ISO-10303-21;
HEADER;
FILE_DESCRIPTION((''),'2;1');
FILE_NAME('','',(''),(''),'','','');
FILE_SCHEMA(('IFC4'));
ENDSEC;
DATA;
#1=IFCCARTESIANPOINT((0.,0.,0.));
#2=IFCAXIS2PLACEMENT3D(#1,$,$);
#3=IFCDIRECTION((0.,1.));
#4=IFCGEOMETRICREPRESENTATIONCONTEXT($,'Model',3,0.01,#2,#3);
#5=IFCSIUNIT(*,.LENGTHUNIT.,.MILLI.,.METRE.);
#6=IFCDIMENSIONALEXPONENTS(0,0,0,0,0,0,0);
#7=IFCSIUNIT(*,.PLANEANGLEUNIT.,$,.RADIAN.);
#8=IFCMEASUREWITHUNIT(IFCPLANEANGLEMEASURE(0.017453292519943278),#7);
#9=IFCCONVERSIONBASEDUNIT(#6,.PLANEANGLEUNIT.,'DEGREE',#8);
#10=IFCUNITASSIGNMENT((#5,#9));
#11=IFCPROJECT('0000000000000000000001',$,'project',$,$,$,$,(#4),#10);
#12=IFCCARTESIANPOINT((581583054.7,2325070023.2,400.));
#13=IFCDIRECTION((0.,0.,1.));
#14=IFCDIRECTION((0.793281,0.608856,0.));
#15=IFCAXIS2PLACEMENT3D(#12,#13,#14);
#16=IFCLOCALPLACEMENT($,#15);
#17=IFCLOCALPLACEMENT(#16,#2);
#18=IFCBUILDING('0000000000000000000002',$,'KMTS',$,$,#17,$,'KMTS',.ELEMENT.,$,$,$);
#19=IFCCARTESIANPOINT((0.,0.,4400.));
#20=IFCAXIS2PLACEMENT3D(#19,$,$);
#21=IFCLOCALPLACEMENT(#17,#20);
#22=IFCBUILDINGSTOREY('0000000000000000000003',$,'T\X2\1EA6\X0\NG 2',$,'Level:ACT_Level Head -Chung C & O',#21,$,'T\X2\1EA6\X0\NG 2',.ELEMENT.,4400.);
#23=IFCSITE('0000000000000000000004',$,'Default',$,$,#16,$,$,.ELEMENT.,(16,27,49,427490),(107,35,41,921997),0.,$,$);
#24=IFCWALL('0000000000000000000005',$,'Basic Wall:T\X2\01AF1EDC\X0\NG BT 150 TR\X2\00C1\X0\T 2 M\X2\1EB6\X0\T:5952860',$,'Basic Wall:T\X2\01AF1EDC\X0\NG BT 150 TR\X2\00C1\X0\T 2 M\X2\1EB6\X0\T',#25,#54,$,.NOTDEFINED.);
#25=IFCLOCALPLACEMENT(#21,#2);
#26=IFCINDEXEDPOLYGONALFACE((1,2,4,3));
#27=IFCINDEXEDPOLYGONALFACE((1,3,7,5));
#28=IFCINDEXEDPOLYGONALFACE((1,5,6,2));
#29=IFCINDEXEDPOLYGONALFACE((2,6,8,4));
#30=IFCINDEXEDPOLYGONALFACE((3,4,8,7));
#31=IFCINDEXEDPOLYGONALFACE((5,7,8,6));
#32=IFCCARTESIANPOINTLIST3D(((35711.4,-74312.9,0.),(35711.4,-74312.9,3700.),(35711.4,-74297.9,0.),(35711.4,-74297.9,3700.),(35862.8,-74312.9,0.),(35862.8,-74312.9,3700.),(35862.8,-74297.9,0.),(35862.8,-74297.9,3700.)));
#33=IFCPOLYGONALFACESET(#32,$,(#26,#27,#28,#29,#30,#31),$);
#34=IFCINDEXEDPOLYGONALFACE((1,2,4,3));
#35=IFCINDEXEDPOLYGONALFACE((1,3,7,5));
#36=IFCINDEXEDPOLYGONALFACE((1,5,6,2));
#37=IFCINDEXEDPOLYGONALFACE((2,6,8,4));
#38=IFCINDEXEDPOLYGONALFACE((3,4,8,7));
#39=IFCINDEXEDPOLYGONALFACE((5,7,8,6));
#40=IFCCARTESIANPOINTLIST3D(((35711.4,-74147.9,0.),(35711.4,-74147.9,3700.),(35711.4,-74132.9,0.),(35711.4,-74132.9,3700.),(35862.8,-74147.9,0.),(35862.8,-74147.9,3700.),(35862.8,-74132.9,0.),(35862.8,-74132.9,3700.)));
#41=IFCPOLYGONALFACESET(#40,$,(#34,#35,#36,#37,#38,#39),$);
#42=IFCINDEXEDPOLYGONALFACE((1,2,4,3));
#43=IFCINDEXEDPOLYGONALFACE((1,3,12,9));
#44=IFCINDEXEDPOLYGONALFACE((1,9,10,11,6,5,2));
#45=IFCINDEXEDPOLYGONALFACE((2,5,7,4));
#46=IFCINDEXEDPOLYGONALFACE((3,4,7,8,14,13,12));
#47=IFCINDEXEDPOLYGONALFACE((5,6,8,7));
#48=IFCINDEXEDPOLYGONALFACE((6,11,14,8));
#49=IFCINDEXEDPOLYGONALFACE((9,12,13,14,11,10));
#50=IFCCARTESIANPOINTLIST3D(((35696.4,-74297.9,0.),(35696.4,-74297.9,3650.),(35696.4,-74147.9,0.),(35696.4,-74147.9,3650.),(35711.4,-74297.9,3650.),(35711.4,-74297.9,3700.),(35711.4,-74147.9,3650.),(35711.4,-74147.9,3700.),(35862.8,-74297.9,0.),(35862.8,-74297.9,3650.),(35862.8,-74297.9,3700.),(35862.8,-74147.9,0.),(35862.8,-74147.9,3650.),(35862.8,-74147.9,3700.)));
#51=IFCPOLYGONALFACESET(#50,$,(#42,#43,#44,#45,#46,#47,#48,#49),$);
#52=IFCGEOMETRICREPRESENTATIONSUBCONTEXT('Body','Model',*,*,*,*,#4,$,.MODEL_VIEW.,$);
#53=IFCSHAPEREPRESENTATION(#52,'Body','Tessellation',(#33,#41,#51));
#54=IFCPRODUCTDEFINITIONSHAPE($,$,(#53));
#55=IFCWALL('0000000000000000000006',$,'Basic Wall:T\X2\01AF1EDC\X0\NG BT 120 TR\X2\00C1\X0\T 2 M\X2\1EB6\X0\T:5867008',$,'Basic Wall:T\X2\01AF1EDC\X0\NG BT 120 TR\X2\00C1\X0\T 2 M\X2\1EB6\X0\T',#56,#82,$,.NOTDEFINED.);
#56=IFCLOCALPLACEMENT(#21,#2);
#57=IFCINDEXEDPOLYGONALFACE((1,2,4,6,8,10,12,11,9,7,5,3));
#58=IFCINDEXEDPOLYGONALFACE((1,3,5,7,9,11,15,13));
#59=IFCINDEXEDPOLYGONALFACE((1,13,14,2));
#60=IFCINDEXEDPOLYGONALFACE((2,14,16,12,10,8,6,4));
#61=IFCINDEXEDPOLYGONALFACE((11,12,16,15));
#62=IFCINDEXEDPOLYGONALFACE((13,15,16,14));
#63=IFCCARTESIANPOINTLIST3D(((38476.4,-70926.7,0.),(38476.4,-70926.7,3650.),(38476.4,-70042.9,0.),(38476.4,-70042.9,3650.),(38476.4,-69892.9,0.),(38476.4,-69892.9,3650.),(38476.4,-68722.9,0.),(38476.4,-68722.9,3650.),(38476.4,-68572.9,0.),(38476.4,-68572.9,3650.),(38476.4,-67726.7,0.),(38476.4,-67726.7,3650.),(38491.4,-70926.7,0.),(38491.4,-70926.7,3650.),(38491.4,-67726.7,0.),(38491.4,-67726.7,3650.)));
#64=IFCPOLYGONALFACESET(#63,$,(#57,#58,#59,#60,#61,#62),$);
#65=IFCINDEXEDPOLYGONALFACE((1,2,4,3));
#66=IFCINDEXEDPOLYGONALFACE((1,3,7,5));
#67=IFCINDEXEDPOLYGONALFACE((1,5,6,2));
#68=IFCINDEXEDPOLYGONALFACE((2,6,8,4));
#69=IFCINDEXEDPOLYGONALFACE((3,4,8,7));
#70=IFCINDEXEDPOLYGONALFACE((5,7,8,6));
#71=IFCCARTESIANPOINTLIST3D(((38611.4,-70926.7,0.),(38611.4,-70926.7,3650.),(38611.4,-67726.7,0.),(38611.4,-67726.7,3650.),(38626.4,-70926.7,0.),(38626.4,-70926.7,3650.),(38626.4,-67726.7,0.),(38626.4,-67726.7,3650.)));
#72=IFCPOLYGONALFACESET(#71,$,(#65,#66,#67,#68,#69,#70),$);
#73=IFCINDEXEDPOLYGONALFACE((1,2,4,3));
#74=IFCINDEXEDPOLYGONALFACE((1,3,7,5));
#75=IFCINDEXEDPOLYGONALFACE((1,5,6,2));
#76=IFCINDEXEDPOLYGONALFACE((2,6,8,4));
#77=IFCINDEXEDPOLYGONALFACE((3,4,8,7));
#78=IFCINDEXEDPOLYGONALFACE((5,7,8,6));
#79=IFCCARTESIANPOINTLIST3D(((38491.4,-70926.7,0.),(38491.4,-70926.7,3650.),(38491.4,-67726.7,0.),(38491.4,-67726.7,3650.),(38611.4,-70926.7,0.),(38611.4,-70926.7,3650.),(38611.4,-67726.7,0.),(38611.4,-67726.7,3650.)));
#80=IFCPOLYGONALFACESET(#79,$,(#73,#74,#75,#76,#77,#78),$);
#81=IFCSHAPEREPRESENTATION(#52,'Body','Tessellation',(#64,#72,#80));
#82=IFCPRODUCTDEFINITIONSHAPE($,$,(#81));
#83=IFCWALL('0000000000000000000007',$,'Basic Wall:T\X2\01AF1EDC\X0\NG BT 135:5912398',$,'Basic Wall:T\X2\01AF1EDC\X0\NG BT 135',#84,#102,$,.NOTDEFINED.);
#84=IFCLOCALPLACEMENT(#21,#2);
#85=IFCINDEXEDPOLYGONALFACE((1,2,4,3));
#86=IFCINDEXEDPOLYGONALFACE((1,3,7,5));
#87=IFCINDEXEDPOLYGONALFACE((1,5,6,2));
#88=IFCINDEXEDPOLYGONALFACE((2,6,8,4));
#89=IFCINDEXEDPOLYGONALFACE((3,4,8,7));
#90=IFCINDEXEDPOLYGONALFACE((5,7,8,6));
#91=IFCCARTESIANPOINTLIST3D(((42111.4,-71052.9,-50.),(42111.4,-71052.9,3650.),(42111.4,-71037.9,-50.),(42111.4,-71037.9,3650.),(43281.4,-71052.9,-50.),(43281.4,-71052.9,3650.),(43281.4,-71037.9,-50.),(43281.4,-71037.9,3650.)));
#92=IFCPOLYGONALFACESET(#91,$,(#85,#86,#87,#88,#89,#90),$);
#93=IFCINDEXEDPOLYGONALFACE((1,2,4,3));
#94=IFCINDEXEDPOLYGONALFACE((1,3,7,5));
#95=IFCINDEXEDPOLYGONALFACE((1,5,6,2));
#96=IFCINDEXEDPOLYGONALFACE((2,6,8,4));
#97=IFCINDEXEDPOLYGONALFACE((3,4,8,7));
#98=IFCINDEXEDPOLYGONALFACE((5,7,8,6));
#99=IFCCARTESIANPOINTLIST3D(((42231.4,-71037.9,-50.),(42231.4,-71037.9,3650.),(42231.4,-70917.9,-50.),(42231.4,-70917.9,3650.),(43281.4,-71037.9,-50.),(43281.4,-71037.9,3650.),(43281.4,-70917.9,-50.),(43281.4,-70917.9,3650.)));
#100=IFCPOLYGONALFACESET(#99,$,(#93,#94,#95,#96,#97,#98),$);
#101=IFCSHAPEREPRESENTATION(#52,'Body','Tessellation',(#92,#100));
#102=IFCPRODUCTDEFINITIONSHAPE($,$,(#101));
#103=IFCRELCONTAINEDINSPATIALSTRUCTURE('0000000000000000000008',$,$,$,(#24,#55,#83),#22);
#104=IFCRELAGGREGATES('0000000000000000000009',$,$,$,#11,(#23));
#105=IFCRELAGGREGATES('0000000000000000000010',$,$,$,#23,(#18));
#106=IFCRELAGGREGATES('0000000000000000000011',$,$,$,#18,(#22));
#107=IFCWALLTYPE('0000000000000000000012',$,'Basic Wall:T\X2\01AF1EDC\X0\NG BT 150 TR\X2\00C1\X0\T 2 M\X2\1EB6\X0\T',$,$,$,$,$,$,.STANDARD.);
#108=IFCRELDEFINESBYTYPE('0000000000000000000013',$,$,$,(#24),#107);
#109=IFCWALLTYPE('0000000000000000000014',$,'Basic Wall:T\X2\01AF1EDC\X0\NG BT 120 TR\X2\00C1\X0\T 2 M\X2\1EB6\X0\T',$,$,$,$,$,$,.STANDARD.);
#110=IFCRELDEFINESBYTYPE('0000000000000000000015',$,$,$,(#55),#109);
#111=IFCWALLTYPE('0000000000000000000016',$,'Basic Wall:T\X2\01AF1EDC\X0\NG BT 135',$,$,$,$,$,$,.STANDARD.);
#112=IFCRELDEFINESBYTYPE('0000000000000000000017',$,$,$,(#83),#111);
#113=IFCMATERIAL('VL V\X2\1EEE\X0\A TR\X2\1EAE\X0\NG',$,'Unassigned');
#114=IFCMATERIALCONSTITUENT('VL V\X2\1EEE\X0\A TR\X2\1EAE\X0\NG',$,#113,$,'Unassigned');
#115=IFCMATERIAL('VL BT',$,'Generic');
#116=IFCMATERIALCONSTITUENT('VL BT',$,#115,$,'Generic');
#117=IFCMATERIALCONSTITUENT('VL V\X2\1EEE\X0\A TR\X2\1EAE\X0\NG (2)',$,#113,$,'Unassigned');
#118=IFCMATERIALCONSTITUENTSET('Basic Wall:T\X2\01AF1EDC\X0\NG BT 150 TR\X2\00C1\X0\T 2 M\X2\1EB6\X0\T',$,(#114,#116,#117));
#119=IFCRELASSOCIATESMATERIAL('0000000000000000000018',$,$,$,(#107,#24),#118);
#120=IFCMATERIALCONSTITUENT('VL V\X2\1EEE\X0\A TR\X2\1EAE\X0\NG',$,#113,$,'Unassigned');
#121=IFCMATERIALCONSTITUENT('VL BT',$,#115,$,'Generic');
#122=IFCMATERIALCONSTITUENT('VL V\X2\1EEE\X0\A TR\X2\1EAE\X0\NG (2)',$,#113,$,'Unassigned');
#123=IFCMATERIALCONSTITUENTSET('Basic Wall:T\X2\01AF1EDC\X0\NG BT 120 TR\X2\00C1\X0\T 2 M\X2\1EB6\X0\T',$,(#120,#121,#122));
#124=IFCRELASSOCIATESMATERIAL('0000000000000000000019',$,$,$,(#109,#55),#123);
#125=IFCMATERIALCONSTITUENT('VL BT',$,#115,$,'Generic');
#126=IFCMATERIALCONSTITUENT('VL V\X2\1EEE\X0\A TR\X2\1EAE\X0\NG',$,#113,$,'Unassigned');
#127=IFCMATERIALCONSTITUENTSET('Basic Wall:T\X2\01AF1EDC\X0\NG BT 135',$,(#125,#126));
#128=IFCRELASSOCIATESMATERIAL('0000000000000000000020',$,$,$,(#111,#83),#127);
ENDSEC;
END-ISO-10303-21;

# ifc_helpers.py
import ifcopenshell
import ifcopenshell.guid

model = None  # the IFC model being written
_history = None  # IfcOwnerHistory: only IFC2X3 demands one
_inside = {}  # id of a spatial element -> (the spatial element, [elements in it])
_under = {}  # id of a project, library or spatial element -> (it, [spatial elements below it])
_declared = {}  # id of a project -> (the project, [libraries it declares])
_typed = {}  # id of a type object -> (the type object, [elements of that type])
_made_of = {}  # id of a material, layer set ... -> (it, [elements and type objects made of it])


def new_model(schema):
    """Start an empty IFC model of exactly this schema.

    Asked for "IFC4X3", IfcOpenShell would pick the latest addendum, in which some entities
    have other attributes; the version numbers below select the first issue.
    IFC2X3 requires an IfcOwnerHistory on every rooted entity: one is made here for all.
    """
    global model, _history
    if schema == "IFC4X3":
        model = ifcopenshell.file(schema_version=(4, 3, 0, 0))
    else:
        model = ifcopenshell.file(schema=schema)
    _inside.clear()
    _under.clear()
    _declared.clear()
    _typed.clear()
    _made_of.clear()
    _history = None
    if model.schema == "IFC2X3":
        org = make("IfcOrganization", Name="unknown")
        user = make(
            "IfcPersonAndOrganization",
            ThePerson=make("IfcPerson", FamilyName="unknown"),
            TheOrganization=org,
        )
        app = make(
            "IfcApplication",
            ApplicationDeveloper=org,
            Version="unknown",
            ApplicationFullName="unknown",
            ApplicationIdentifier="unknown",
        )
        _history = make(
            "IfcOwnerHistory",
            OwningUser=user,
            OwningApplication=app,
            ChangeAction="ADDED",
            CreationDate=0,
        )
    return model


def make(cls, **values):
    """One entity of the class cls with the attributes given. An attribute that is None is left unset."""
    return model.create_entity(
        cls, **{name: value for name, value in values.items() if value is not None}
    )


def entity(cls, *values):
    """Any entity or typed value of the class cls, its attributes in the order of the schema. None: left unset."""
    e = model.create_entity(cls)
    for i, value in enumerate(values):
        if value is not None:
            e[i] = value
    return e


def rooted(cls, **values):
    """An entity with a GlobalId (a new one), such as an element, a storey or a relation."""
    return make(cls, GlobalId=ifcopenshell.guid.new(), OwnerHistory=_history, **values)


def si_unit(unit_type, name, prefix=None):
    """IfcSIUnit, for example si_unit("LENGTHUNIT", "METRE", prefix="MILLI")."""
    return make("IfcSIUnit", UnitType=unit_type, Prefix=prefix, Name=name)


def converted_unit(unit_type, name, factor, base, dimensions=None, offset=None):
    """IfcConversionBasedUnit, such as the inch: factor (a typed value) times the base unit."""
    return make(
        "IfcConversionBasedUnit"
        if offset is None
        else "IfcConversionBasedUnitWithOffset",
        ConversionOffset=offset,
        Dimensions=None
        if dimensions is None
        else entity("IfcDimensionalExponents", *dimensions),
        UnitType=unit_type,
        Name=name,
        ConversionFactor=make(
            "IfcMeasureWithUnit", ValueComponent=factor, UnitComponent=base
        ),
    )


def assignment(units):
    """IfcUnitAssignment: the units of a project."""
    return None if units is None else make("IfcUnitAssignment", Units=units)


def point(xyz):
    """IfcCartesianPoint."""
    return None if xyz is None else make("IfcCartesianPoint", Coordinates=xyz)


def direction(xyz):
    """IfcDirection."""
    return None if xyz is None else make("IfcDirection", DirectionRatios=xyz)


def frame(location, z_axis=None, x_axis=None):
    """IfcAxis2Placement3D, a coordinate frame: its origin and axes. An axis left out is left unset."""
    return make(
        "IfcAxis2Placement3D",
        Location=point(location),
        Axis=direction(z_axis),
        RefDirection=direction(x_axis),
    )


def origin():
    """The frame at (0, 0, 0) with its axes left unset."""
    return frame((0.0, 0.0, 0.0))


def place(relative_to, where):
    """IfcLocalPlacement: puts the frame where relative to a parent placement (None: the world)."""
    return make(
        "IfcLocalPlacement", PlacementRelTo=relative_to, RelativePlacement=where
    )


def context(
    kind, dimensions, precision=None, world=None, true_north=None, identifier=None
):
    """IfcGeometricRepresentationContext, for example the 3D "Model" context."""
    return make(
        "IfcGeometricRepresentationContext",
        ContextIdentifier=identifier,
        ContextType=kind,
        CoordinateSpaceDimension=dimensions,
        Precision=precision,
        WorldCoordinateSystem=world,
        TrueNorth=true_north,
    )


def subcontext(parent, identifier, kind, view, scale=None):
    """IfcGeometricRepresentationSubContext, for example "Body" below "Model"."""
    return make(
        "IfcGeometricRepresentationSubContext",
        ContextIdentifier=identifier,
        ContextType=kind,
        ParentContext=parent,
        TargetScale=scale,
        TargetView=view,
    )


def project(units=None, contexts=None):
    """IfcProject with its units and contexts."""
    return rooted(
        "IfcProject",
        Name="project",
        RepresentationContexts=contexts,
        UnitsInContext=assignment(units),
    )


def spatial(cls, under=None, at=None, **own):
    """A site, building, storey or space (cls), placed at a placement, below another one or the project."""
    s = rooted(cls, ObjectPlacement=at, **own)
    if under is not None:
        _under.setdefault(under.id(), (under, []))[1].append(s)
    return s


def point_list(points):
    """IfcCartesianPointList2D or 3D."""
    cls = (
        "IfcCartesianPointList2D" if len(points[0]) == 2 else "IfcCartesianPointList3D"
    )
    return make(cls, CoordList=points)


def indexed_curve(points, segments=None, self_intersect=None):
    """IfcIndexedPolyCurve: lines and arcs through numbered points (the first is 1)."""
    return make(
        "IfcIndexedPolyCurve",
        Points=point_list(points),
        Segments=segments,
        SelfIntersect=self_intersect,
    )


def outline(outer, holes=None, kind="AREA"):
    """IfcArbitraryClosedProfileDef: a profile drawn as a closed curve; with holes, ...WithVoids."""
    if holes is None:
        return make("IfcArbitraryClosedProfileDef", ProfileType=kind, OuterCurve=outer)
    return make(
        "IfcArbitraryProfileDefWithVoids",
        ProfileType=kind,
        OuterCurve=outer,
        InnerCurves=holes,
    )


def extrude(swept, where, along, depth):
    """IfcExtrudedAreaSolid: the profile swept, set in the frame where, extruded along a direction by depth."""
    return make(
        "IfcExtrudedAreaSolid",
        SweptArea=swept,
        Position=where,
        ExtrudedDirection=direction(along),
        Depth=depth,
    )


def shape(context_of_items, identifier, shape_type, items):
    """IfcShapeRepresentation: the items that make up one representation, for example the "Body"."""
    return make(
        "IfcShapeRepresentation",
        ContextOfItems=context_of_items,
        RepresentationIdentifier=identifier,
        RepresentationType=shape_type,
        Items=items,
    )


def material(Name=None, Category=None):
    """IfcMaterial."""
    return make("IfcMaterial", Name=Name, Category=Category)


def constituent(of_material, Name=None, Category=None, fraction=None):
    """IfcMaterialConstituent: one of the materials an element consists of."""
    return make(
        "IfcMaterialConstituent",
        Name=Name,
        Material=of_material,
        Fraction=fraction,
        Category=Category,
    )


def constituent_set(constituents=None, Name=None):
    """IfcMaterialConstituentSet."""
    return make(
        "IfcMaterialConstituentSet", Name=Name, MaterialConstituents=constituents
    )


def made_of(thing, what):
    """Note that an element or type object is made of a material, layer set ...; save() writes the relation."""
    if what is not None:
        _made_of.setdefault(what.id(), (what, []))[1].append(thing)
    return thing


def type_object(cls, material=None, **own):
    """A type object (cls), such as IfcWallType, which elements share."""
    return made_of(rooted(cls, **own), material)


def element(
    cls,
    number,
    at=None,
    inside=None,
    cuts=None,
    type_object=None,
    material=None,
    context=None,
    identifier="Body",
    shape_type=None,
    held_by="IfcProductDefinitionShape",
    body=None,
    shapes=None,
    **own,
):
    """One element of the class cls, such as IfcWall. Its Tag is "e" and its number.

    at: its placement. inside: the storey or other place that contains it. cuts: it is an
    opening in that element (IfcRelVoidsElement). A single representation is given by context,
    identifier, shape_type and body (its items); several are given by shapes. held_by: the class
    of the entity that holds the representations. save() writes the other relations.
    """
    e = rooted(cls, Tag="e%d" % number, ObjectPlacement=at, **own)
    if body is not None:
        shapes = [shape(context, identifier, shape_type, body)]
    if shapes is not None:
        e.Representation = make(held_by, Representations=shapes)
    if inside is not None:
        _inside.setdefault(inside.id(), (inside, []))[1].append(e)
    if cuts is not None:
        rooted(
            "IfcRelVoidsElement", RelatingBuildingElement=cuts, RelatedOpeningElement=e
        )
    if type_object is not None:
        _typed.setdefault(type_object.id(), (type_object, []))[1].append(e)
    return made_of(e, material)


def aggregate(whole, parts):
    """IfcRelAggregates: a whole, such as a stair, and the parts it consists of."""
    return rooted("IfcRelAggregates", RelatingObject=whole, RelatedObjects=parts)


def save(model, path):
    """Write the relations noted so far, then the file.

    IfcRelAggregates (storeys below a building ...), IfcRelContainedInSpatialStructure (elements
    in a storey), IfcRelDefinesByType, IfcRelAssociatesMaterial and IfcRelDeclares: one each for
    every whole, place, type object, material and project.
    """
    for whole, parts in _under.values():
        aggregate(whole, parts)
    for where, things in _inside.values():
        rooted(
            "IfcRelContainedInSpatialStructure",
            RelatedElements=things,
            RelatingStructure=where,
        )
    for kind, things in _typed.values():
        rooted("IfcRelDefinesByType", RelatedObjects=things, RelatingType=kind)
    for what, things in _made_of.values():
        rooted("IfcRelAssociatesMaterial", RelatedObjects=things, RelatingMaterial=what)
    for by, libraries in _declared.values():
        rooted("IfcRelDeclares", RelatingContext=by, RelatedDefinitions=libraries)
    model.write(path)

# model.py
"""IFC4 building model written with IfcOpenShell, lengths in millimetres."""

from ifc_helpers import new_model, entity, si_unit, converted_unit, direction, frame, origin, place, context, subcontext, project, spatial, indexed_curve, outline, extrude, material, constituent, constituent_set, type_object, element, save


model = new_model("IFC4")

# Units and contexts
model_context = context("Model", 3, precision=0.01, world=origin(), true_north=direction((0.0, 1.0)))
body_context = subcontext(model_context, "Body", "Model", "MODEL_VIEW")
ifc_project = project(units=[si_unit("LENGTHUNIT", "METRE", prefix="MILLI"), converted_unit("PLANEANGLEUNIT", "DEGREE", entity("IfcPlaneAngleMeasure", 0.017453292519943278), si_unit("PLANEANGLEUNIT", "RADIAN"), dimensions=[0, 0, 0, 0, 0, 0, 0])], contexts=[model_context])

# Site, building, storey
site_placement = place(None, frame((581583054.7, 2325070023.2, 400.0), z_axis=(0.0, 0.0, 1.0), x_axis=(0.793281, 0.608856, 0.0)))
site = spatial("IfcSite", under=ifc_project, at=site_placement, Name="Default", CompositionType="ELEMENT", RefLatitude=(16, 27, 49, 427490), RefLongitude=(107, 35, 41, 921997), RefElevation=0.0)
building_placement = place(site_placement, origin())
building = spatial("IfcBuilding", under=site, at=building_placement, Name="KMTS", LongName="KMTS", CompositionType="ELEMENT")
storey_placement = place(building_placement, frame((0.0, 0.0, 4400.0)))
storey = spatial("IfcBuildingStorey", under=building, at=storey_placement, Name="TẦNG 2", ObjectType="Level:ACT_Level Head -Chung C & O", LongName="TẦNG 2", CompositionType="ELEMENT", Elevation=4400.0)

# Shared definitions
ifc_material_1 = material(Name="VL VỮA TRẮNG", Category="Unassigned")
ifc_constituent_1 = constituent(ifc_material_1, Name="VL VỮA TRẮNG", Category="Unassigned")
ifc_material_2 = material(Name="VL BT", Category="Generic")
ifc_constituent_2 = constituent(ifc_material_2, Name="VL BT", Category="Generic")
ifc_constituent_3 = constituent(ifc_material_1, Name="VL VỮA TRẮNG (2)", Category="Unassigned")
ifc_constituent_set_1 = constituent_set(constituents=[ifc_constituent_1, ifc_constituent_2, ifc_constituent_3], Name="Basic Wall:TƯỜNG BT 150 TRÁT 2 MẶT")
wall_type_1 = type_object("IfcWallType", Name="Basic Wall:TƯỜNG BT 150 TRÁT 2 MẶT", PredefinedType="STANDARD", material=ifc_constituent_set_1)

# Wall
wall_1_placement = place(storey_placement, frame((35711.4, -74222.9, 0.0)))
element("IfcWall", 1, at=wall_1_placement, inside=storey, type_object=wall_type_1, material=ifc_constituent_set_1, Name="Basic Wall:TƯỜNG BT 150 TRÁT 2 MẶT:5952860", ObjectType="Basic Wall:TƯỜNG BT 150 TRÁT 2 MẶT", PredefinedType="NOTDEFINED", context=body_context, shape_type="SweptSolid", body=[
    extrude(outline(indexed_curve([(-7.5, -75.7), (7.5, -75.7), (7.5, 75.7), (-7.5, 75.7), (-7.5, -75.7)], self_intersect=False)), frame((75.7, -82.5, 0.0), z_axis=(0.0, 0.0, 1.0), x_axis=(0.0, 1.0, 0.0)), (0.0, 0.0, 1.0), 3700.0),
    extrude(outline(indexed_curve([(-7.5, -75.7), (7.5, -75.7), (7.5, 75.7), (-7.5, 75.7), (-7.5, -75.7)], self_intersect=False)), frame((75.7, 82.5, 0.0), z_axis=(0.0, 0.0, 1.0), x_axis=(0.0, -1.0, 0.0)), (0.0, 0.0, 1.0), 3700.0),
    extrude(outline(indexed_curve([(-2621.4, -75.6), (1028.6, -75.6), (1028.6, -60.6), (1078.6, -60.6), (1078.6, 90.8), (1028.6, 90.8), (-2621.4, 90.8), (-2621.4, -75.6)], self_intersect=False)), frame((60.6, -75.0, 2621.4), z_axis=(0.0, 1.0, 0.0), x_axis=(0.0, 0.0, 1.0)), (0.0, 0.0, 1.0), 150.0),
])
ifc_constituent_4 = constituent(ifc_material_1, Name="VL VỮA TRẮNG", Category="Unassigned")
ifc_constituent_5 = constituent(ifc_material_2, Name="VL BT", Category="Generic")
ifc_constituent_6 = constituent(ifc_material_1, Name="VL VỮA TRẮNG (2)", Category="Unassigned")
ifc_constituent_set_2 = constituent_set(constituents=[ifc_constituent_4, ifc_constituent_5, ifc_constituent_6], Name="Basic Wall:TƯỜNG BT 120 TRÁT 2 MẶT")
wall_type_2 = type_object("IfcWallType", Name="Basic Wall:TƯỜNG BT 120 TRÁT 2 MẶT", PredefinedType="STANDARD", material=ifc_constituent_set_2)

# Wall
wall_2_placement = place(storey_placement, frame((38551.4, -67726.7, 0.0), z_axis=(0.0, 0.0, 1.0), x_axis=(0.0, -1.0, 0.0)))
element("IfcWall", 2, at=wall_2_placement, inside=storey, type_object=wall_type_2, material=ifc_constituent_set_2, Name="Basic Wall:TƯỜNG BT 120 TRÁT 2 MẶT:5867008", ObjectType="Basic Wall:TƯỜNG BT 120 TRÁT 2 MẶT", PredefinedType="NOTDEFINED", context=body_context, shape_type="SweptSolid", body=[
    extrude(outline(indexed_curve([(-744.4, -3.7), (-594.4, -3.7), (575.6, -3.7), (725.6, -3.7), (1609.4, -3.7), (1609.4, 11.3), (-1590.6, 11.3), (-1590.6, -3.7), (-744.4, -3.7)], self_intersect=False)), frame((1590.6, -71.3, 0.0)), (0.0, 0.0, 1.0), 3650.0),
    extrude(outline(indexed_curve([(-7.5, -1600.0), (7.5, -1600.0), (7.5, 1600.0), (-7.5, 1600.0), (-7.5, -1600.0)], self_intersect=False)), frame((1600.0, 67.5, 0.0), z_axis=(0.0, 0.0, 1.0), x_axis=(0.0, -1.0, 0.0)), (0.0, 0.0, 1.0), 3650.0),
    extrude(outline(indexed_curve([(-1600.0, -60.0), (1600.0, -60.0), (1600.0, 60.0), (-1600.0, 60.0), (-1600.0, -60.0)], self_intersect=False)), frame((1600.0, 0.0, 0.0)), (0.0, 0.0, 1.0), 3650.0),
])

# Wall
ifc_constituent_7 = constituent(ifc_material_2, Name="VL BT", Category="Generic")
ifc_constituent_8 = constituent(ifc_material_1, Name="VL VỮA TRẮNG", Category="Unassigned")
ifc_constituent_set_3 = constituent_set(constituents=[ifc_constituent_7, ifc_constituent_8], Name="Basic Wall:TƯỜNG BT 135")
wall_type_3 = type_object("IfcWallType", Name="Basic Wall:TƯỜNG BT 135", PredefinedType="STANDARD", material=ifc_constituent_set_3)
wall_3_placement = place(storey_placement, frame((42231.4, -70985.4, -50.0)))
element("IfcWall", 3, at=wall_3_placement, inside=storey, type_object=wall_type_3, material=ifc_constituent_set_3, Name="Basic Wall:TƯỜNG BT 135:5912398", ObjectType="Basic Wall:TƯỜNG BT 135", PredefinedType="NOTDEFINED", context=body_context, shape_type="SweptSolid", body=[
    extrude(outline(indexed_curve([(-7.5, -585.0), (7.5, -585.0), (7.5, 585.0), (-7.5, 585.0), (-7.5, -585.0)], self_intersect=False)), frame((465.0, -60.0, 0.0), z_axis=(0.0, 0.0, 1.0), x_axis=(0.0, 1.0, 0.0)), (0.0, 0.0, 1.0), 3700.0),
    extrude(outline(indexed_curve([(-60.0, -525.0), (60.0, -525.0), (60.0, 525.0), (-60.0, 525.0), (-60.0, -525.0)], self_intersect=False)), frame((525.0, 7.5, 0.0), z_axis=(0.0, 0.0, 1.0), x_axis=(0.0, -1.0, 0.0)), (0.0, 0.0, 1.0), 3700.0),
])

save(model, "model.ifc")
